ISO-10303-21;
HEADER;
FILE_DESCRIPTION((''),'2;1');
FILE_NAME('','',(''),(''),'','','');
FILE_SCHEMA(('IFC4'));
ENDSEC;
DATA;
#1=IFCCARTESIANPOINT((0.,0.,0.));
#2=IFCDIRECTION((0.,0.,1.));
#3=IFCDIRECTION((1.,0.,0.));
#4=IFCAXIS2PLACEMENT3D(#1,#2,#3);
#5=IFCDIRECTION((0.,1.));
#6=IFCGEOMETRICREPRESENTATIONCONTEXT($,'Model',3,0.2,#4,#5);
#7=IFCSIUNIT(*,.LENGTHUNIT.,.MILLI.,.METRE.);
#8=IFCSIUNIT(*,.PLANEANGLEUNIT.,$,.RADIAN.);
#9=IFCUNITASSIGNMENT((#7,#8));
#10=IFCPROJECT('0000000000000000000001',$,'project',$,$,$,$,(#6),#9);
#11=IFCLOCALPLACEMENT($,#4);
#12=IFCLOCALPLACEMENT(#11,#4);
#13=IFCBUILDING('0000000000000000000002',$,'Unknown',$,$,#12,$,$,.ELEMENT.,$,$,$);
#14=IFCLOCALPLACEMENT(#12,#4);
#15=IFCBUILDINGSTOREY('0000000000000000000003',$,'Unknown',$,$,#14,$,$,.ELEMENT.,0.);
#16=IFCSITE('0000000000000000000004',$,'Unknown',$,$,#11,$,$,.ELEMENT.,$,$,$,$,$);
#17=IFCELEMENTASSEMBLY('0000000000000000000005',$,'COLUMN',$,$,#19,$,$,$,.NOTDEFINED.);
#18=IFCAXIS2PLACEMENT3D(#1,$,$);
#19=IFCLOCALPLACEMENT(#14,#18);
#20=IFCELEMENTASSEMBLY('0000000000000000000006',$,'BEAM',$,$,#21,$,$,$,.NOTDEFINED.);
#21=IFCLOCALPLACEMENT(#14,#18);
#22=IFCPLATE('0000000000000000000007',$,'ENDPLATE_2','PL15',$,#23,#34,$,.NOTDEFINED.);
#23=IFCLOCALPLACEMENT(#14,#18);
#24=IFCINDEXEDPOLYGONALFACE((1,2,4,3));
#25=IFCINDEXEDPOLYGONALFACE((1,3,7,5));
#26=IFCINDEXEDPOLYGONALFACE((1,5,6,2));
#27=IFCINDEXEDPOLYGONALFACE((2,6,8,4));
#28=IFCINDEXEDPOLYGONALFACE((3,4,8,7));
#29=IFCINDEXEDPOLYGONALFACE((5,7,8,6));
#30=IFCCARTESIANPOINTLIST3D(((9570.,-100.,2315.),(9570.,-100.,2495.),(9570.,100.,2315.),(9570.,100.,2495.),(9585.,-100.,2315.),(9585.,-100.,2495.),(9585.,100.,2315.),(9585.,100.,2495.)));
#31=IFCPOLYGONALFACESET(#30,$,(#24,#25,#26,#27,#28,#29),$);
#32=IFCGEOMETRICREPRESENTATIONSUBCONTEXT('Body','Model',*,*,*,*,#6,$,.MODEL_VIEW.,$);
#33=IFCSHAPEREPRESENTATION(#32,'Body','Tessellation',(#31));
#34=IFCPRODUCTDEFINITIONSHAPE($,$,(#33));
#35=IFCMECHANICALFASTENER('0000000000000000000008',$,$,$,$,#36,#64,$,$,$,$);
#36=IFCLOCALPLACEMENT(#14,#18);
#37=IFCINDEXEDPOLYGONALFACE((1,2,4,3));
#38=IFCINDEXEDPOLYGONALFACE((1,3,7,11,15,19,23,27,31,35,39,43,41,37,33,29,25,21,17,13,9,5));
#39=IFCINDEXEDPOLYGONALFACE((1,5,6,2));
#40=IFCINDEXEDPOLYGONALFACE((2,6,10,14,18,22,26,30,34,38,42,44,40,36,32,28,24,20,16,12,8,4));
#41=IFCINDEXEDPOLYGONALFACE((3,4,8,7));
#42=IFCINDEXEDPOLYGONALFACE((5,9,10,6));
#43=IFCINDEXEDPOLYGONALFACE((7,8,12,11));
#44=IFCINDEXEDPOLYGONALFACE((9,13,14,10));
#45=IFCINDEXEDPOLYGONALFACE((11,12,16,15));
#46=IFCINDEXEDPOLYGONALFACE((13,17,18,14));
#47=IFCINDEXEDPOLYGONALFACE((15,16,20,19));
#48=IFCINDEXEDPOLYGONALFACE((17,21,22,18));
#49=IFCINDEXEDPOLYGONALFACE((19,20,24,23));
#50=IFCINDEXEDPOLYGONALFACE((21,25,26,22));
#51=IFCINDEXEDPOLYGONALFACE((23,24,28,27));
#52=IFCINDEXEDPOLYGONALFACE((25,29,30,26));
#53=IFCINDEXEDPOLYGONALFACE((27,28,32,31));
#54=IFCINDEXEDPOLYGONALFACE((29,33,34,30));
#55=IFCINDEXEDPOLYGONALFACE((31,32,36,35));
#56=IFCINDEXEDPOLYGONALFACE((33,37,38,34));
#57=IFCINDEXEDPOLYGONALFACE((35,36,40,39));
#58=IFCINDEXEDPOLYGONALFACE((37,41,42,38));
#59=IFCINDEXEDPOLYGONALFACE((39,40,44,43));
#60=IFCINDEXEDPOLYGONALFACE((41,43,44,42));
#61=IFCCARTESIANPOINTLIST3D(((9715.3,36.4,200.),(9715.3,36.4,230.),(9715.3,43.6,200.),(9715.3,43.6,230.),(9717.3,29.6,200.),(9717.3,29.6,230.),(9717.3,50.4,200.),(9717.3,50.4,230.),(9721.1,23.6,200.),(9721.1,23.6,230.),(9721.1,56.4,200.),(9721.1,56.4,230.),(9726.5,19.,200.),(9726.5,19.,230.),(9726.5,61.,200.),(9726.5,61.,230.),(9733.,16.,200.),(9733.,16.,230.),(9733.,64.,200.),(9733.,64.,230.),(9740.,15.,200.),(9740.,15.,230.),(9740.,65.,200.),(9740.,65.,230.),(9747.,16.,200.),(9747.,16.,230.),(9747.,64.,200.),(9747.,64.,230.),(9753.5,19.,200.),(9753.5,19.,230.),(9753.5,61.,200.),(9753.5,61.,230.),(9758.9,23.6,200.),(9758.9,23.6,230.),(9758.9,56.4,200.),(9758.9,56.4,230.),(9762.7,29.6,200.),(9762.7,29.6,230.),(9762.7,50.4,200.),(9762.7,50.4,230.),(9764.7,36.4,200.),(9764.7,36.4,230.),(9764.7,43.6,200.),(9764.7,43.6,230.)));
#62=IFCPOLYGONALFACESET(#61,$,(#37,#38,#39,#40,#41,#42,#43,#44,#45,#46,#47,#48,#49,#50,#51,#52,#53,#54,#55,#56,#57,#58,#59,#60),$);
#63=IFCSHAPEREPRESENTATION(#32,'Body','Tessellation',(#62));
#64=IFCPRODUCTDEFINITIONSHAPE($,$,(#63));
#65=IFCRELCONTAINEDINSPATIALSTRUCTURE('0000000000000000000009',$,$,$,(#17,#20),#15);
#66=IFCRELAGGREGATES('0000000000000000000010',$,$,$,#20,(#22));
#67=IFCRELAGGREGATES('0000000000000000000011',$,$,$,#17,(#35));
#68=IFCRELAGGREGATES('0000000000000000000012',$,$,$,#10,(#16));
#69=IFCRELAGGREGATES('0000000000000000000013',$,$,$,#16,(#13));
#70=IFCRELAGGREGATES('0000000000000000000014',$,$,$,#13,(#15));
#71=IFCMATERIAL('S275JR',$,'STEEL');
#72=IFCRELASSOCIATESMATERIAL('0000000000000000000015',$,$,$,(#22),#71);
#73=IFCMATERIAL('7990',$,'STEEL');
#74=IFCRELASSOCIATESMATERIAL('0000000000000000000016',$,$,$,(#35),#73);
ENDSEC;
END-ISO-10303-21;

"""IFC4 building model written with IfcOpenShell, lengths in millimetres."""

from ifc_helpers import new_model, si_unit, direction, frame, origin_with_axes, place, context, subcontext, project, spatial, line, arc, indexed_curve, outline, extrude, source, transform, mapped, material, element, aggregate, save


model = new_model("IFC4")

# Units and contexts
model_context = context("Model", 3, precision=0.2, world=origin_with_axes(), true_north=direction((0.0, 1.0)))
body_context = subcontext(model_context, "Body", "Model", "MODEL_VIEW")
ifc_project = project(units=[si_unit("LENGTHUNIT", "METRE", prefix="MILLI"), si_unit("PLANEANGLEUNIT", "RADIAN")], contexts=[model_context])

# Site, building, storey
site_placement = place(None, origin_with_axes())
site = spatial("IfcSite", under=ifc_project, at=site_placement, Name="Unknown", CompositionType="ELEMENT")
building_placement = place(site_placement, origin_with_axes())
building = spatial("IfcBuilding", under=site, at=building_placement, Name="Unknown", CompositionType="ELEMENT")
storey_placement = place(building_placement, origin_with_axes())
storey = spatial("IfcBuildingStorey", under=building, at=storey_placement, Name="Unknown", CompositionType="ELEMENT", Elevation=0.0)

# Shared definitions
ifc_material_1 = material(Name="S275JR", Category="STEEL")

# Element assembly
assembly_1_placement = place(storey_placement, frame((9800.0, 0.0, 200.0), z_axis=(-1.0, 0.0, 0.0), x_axis=(0.0, 0.0, 1.0)))
assembly_1 = element("IfcElementAssembly", 1, at=assembly_1_placement, inside=storey, Name="COLUMN", PredefinedType="NOTDEFINED")

# Element assembly, plate
assembly_2_placement = place(storey_placement, frame((9800.0, 0.0, 2405.0), z_axis=(0.0, 1.0, 0.0), x_axis=(-1.0, 0.0, 0.0)))
assembly_2 = element("IfcElementAssembly", 2, at=assembly_2_placement, inside=storey, Name="BEAM", PredefinedType="NOTDEFINED")
plate_1_placement = place(assembly_2_placement, frame((222.5, -90.0, -100.0), z_axis=(1.0, 0.0, 0.0), x_axis=(0.0, 1.0, 0.0)))
plate_1 = element("IfcPlate", 3, at=plate_1_placement, material=ifc_material_1, Name="ENDPLATE_2", Description="PL15", PredefinedType="NOTDEFINED", context=body_context, shape_type="SolidModel", body=[
    extrude(outline(indexed_curve([(0.0, 0.0), (180.0, 0.0), (180.0, 200.0), (0.0, 200.0)], segments=[line(1, 2, 3, 4, 1)])), frame((0.0, 0.0, 7.5), z_axis=(0.0, 0.0, 1.0), x_axis=(1.0, 0.0, 0.0)), (0.0, -0.000002, -1.0), 15.0),
])
aggregate(assembly_2, [plate_1])

# Mechanical fastener
ifc_material_2 = material(Name="7990", Category="STEEL")
shared_shape_1 = source(origin_with_axes(), body_context, "Body", "SweptSolid", [
    extrude(outline(indexed_curve([(25.0, 0.0), (0.0, 25.0), (-25.0, 0.0), (0.0, -25.0)], segments=[arc(1, 2, 3), arc(3, 4, 1)])), frame((0.0, 0.0, 0.0), z_axis=(0.0, -0.000002, -1.0), x_axis=(0.0, 1.0, 0.0)), (0.0, 0.0, 1.0), 30.0),
])
mechanical_fastener_1_placement = place(assembly_1_placement, frame((30.0, 40.0, 60.0), z_axis=(1.0, 0.0, 0.0), x_axis=(0.0, -0.000002, -1.0)))
mechanical_fastener_1 = element("IfcMechanicalFastener", 4, at=mechanical_fastener_1_placement, material=ifc_material_2, context=body_context, shape_type="MappedRepresentation", body=[
    mapped(shared_shape_1, transform((0.0, 0.0, 0.0))),
])
aggregate(assembly_1, [mechanical_fastener_1])

save(model, "model.ifc")
